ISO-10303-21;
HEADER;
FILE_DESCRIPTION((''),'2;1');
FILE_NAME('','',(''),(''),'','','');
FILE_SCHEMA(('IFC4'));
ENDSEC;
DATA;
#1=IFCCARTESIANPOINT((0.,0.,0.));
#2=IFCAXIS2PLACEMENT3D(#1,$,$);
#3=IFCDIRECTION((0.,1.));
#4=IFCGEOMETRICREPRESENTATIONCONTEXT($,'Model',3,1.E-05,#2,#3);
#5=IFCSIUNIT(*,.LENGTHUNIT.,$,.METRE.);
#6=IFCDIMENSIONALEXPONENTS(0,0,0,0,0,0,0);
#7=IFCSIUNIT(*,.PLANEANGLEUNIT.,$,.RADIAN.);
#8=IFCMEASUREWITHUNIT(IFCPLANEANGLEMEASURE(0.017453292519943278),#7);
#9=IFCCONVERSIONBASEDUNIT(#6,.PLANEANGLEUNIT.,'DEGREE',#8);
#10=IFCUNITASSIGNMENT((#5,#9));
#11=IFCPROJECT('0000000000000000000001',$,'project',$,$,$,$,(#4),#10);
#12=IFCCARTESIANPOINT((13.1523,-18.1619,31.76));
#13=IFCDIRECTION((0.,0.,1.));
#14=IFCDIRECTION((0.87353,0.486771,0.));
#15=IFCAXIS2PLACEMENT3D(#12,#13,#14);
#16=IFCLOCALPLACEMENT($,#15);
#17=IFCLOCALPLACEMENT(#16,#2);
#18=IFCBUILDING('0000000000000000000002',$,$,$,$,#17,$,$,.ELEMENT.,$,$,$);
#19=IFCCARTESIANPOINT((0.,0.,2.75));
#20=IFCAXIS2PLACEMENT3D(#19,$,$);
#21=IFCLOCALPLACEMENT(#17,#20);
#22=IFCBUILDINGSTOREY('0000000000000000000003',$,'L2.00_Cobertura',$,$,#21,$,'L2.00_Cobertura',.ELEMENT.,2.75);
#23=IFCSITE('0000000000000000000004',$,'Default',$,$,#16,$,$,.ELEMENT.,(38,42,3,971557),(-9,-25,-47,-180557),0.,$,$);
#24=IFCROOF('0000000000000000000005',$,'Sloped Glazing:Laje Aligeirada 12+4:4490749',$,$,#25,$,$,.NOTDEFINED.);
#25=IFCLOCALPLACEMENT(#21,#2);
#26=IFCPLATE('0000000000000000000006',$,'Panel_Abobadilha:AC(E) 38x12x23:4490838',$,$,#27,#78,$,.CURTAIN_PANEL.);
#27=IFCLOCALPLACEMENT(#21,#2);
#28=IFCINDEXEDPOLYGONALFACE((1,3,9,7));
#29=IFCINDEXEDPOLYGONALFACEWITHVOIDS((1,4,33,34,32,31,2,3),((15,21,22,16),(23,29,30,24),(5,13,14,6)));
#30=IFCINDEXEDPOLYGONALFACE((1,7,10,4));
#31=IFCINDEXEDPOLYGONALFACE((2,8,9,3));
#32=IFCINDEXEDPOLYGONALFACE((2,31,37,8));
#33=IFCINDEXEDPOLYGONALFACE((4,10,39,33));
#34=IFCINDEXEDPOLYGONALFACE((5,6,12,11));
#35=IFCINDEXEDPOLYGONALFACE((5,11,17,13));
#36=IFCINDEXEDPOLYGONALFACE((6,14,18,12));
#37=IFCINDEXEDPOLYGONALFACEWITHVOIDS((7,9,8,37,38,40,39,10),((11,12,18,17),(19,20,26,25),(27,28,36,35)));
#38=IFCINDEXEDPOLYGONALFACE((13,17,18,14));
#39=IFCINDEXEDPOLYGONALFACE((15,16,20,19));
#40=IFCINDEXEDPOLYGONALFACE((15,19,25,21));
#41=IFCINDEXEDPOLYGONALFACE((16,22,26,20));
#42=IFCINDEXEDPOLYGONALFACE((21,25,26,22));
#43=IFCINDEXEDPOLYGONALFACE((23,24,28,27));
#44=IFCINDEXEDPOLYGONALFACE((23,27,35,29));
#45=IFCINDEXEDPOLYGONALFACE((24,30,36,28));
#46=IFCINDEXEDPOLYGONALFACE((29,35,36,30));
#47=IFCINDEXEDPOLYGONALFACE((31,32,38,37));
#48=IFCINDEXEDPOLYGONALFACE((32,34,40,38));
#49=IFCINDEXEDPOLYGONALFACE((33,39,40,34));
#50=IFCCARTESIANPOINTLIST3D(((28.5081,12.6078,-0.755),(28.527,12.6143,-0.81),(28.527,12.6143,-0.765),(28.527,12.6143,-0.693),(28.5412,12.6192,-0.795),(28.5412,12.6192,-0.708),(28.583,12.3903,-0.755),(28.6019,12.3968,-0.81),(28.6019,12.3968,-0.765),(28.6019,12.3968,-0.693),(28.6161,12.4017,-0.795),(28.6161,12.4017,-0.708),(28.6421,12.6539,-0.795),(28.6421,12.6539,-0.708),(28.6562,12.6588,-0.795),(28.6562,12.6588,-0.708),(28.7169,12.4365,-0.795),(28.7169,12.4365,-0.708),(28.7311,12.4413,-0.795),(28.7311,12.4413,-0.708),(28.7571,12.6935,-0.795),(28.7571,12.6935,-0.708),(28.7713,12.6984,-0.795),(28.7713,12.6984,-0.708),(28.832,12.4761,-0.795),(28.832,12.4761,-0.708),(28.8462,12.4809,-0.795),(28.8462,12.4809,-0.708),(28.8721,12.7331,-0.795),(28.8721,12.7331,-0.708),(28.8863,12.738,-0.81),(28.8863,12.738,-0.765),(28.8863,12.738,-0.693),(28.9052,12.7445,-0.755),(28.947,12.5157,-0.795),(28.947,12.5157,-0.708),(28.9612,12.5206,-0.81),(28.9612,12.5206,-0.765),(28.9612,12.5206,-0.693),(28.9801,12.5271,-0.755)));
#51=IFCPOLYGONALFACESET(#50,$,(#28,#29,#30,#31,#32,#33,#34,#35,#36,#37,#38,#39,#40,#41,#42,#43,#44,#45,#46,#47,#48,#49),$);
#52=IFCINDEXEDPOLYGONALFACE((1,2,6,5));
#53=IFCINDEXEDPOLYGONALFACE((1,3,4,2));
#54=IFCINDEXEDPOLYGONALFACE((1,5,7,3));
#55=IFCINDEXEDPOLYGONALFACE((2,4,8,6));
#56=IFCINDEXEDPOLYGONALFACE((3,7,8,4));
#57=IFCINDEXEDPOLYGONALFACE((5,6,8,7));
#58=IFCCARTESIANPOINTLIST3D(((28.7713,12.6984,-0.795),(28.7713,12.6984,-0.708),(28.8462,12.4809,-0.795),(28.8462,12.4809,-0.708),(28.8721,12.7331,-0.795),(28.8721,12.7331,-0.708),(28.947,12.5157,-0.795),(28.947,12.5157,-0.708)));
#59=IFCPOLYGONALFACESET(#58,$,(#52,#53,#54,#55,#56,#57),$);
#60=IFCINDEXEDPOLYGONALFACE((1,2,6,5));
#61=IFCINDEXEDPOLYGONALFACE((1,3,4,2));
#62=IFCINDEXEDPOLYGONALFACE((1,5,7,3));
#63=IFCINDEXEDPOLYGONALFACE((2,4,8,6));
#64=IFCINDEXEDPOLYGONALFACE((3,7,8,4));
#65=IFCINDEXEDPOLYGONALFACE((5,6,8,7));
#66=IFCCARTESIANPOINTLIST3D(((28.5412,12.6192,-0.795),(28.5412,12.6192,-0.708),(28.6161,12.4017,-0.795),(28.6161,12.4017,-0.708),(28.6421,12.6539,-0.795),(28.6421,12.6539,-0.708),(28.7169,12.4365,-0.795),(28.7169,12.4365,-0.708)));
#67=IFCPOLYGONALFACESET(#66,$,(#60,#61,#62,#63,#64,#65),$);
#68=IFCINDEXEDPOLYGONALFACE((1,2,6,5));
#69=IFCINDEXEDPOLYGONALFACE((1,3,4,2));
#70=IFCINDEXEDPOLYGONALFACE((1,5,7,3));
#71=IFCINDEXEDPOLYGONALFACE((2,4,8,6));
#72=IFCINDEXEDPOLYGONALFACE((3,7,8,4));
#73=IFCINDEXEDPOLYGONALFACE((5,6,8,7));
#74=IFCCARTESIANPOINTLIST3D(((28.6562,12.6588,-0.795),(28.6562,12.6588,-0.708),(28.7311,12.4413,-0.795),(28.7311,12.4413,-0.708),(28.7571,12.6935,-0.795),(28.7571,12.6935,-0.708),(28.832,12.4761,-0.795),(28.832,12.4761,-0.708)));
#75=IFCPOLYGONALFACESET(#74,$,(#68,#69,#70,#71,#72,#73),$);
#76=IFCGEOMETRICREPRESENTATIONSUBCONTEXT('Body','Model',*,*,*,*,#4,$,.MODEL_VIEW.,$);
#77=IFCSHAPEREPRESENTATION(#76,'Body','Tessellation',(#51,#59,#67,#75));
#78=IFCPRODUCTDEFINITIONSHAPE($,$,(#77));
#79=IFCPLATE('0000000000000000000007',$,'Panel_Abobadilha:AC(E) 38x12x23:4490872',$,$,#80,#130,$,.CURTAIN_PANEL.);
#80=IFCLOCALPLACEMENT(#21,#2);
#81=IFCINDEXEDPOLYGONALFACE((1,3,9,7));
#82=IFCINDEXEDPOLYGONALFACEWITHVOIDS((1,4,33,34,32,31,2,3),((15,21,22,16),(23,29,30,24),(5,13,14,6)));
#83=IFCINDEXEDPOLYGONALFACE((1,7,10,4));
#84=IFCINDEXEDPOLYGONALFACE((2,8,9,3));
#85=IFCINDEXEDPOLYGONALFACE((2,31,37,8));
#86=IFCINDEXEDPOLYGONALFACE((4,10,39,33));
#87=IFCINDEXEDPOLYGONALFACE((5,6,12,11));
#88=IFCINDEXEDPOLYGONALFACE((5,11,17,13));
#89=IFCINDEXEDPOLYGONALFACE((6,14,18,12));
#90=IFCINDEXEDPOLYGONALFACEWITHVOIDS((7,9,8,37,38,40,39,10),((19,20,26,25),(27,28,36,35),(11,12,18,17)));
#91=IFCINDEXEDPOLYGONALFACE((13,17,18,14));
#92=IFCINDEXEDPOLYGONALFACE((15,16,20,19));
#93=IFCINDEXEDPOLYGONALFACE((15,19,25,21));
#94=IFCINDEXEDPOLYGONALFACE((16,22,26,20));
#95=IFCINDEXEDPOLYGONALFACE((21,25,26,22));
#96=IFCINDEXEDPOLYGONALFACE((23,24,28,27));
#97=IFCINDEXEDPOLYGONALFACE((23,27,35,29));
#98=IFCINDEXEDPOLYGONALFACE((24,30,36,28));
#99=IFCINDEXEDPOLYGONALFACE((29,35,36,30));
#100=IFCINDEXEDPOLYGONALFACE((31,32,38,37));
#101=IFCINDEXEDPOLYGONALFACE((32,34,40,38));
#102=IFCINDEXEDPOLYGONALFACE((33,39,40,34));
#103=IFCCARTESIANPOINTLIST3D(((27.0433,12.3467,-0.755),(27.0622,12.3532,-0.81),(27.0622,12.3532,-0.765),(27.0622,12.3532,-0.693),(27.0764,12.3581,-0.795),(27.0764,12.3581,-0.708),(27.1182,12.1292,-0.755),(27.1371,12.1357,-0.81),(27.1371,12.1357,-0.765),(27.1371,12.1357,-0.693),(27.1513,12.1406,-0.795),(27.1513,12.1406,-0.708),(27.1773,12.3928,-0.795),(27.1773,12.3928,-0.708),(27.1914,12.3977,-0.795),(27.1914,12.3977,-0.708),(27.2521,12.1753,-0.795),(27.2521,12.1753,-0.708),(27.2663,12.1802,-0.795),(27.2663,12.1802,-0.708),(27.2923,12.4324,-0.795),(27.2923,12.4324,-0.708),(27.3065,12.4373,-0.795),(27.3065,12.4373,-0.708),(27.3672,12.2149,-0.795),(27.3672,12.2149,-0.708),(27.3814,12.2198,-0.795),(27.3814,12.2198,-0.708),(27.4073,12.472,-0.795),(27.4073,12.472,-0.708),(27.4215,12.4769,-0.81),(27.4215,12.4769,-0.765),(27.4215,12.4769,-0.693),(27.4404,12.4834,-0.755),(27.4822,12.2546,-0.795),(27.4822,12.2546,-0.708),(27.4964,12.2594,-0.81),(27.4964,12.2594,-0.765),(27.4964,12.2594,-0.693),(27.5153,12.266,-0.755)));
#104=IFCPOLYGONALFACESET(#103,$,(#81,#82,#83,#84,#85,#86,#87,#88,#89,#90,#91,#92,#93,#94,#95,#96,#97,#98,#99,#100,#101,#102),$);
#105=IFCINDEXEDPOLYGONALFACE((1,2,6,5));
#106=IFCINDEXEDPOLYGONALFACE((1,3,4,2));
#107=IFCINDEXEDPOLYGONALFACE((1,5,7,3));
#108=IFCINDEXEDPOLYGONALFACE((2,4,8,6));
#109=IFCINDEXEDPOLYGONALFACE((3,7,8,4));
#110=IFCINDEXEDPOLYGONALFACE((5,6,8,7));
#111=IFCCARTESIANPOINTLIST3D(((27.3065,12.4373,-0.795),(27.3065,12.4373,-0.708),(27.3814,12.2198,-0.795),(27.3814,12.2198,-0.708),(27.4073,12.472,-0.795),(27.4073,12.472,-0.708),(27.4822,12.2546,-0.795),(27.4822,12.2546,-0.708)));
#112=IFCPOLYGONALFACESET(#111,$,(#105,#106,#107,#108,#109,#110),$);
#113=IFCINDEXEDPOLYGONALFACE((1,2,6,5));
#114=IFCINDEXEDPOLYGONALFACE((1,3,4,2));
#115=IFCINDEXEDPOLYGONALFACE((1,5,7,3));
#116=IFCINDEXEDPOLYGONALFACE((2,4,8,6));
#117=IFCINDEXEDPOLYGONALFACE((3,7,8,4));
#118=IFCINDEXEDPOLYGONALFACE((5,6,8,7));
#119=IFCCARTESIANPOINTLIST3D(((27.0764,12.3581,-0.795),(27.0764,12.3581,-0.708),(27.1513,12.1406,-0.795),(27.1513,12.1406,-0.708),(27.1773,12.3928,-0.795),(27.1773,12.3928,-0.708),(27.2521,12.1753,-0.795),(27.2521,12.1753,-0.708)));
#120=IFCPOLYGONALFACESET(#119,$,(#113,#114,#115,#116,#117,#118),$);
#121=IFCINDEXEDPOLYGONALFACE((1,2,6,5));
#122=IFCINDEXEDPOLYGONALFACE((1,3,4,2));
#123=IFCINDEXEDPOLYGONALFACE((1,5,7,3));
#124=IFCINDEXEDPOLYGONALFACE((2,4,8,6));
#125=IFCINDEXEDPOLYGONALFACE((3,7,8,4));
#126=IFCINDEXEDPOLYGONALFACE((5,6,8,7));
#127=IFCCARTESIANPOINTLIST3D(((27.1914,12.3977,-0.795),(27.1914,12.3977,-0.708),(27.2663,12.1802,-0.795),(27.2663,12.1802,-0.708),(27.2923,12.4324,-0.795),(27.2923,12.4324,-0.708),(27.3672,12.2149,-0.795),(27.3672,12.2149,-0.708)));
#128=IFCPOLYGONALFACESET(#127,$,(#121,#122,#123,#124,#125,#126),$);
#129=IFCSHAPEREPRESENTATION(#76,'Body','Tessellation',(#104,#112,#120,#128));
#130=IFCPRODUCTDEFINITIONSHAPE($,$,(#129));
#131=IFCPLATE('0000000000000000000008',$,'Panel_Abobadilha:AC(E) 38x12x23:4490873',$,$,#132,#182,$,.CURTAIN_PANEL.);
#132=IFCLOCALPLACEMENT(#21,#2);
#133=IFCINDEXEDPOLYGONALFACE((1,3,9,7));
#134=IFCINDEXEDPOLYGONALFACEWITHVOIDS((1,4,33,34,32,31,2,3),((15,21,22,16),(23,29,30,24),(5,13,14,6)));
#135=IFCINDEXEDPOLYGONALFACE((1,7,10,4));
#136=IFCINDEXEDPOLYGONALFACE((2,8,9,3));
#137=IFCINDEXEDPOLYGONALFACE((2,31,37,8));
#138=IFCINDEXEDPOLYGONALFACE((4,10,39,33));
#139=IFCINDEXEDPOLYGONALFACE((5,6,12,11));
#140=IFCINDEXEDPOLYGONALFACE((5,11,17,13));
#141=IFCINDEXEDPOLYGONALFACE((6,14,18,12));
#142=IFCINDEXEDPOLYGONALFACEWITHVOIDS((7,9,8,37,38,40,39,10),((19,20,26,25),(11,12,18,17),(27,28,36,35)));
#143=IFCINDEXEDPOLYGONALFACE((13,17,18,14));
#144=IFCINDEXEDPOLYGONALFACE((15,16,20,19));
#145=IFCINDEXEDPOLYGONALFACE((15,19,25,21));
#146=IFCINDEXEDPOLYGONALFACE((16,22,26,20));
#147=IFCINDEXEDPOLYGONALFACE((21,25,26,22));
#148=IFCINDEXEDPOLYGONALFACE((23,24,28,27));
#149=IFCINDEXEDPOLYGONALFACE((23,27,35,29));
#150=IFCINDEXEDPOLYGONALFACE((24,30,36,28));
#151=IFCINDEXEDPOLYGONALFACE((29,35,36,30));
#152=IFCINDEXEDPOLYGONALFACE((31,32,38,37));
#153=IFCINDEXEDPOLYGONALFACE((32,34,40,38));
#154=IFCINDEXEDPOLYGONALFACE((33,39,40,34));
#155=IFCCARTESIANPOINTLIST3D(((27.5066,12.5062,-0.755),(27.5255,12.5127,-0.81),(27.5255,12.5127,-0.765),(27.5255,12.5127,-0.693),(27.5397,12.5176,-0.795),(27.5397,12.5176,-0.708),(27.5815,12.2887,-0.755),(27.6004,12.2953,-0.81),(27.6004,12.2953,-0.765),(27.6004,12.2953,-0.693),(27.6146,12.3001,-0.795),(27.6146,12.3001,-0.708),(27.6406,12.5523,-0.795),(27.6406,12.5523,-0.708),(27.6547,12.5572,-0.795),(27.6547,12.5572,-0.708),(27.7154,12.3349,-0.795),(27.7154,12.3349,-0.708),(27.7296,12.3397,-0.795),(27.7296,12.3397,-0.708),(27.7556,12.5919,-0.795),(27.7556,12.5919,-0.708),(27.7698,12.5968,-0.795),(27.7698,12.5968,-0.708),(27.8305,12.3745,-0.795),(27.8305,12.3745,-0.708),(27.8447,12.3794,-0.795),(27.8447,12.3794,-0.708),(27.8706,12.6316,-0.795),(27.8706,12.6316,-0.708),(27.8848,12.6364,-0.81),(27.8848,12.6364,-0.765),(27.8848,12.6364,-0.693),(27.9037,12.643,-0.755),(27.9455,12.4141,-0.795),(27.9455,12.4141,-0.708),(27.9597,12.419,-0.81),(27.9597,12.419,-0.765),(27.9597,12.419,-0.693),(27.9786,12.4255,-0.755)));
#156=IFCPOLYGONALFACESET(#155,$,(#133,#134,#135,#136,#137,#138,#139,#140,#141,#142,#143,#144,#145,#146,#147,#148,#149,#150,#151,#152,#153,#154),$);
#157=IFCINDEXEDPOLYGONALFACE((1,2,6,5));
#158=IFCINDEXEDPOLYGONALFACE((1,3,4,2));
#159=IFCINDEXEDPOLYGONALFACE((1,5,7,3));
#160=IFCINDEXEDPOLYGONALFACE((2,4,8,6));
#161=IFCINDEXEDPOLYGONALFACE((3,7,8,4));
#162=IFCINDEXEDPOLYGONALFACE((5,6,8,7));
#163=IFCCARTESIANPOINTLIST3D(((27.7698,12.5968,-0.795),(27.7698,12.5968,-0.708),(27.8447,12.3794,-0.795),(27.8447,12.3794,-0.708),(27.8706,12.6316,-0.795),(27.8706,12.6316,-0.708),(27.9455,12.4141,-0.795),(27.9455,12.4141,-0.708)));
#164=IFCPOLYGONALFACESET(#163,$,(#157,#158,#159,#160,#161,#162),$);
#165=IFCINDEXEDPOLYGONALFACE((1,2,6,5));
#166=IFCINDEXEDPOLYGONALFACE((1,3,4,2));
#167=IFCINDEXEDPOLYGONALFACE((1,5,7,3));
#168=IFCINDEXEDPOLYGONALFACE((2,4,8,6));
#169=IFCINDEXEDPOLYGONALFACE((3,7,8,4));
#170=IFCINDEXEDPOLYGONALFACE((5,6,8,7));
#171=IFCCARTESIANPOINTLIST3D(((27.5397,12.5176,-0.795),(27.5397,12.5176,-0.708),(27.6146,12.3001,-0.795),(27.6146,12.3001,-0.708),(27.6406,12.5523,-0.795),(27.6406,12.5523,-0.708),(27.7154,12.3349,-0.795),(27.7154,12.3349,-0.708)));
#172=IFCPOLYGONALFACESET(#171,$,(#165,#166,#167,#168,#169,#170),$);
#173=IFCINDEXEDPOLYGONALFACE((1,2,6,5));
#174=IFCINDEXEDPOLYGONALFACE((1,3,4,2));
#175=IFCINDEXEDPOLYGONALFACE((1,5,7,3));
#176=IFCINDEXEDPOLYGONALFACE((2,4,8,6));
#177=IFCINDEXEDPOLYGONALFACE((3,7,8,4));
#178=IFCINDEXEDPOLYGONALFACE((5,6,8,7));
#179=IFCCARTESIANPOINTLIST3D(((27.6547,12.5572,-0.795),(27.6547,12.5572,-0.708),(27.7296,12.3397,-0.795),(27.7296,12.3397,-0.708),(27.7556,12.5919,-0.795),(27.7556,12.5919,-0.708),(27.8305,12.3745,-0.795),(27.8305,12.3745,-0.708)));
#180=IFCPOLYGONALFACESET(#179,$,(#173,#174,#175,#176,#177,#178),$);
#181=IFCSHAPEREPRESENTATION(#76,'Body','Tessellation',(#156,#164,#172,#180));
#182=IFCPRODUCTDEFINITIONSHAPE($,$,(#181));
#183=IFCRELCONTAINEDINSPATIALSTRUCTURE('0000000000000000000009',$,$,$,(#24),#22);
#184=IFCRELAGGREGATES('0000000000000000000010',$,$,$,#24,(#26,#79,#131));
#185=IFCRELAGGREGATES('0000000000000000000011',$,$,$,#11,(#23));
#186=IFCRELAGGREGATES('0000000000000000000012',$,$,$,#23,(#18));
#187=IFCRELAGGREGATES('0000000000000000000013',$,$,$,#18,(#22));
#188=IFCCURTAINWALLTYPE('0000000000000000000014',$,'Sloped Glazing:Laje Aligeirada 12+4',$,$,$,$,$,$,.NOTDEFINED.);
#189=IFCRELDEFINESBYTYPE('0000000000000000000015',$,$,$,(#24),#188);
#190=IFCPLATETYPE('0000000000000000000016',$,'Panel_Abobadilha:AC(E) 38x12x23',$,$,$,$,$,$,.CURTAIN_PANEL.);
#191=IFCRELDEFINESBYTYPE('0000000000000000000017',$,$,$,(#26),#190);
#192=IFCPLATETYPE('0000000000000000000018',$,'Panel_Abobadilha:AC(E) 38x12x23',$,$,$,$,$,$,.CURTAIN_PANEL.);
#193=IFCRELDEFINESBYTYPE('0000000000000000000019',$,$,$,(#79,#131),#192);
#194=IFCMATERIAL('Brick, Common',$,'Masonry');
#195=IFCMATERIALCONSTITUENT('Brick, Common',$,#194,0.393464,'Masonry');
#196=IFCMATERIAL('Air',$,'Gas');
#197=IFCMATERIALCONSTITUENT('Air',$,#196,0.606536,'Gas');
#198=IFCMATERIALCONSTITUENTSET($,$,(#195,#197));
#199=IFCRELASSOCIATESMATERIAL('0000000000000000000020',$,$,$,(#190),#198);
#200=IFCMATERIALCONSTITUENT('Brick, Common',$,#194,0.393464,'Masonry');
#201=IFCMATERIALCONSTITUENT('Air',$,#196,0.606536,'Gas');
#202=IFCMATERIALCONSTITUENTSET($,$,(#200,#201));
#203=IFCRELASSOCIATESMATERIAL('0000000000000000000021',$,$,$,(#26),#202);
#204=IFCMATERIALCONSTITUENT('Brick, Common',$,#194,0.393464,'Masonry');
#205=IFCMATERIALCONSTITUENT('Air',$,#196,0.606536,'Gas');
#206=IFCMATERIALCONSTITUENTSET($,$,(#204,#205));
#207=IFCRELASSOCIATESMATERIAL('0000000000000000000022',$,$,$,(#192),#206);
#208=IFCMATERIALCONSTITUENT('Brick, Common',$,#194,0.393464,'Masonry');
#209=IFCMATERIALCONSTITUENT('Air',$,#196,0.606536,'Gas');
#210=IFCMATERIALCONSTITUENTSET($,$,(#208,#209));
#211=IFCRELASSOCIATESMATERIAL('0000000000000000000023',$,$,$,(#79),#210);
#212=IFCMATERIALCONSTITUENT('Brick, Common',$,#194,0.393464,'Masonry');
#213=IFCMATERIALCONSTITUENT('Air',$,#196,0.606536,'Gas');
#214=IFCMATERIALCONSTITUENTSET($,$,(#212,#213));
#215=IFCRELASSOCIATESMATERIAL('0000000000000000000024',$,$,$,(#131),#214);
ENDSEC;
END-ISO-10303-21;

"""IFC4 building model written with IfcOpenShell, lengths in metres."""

from ifc_helpers import new_model, entity, si_unit, converted_unit, direction, frame, origin, place, context, subcontext, project, spatial, indexed_curve, outline, extrude, source, transform, mapped, material, constituent, constituent_set, type_object, type_shapes, element, aggregate, save


model = new_model("IFC4")

# Units and contexts
model_context = context("Model", 3, precision=1e-05, world=origin(), true_north=direction((0.0, 1.0)))
body_context = subcontext(model_context, "Body", "Model", "MODEL_VIEW")
ifc_project = project(units=[si_unit("LENGTHUNIT", "METRE"), converted_unit("PLANEANGLEUNIT", "DEGREE", entity("IfcPlaneAngleMeasure", 0.017453292519943278), si_unit("PLANEANGLEUNIT", "RADIAN"), dimensions=[0, 0, 0, 0, 0, 0, 0])], contexts=[model_context])

# Site, building, storey
site_placement = place(None, frame((13.1523, -18.1619, 31.76), z_axis=(0.0, 0.0, 1.0), x_axis=(0.87353, 0.486771, 0.0)))
site = spatial("IfcSite", under=ifc_project, at=site_placement, Name="Default", CompositionType="ELEMENT", RefLatitude=(38, 42, 3, 971557), RefLongitude=(-9, -25, -47, -180557), RefElevation=0.0)
building_placement = place(site_placement, origin())
building = spatial("IfcBuilding", under=site, at=building_placement, CompositionType="ELEMENT")
storey_placement = place(building_placement, frame((0.0, 0.0, 2.75)))
storey = spatial("IfcBuildingStorey", under=building, at=storey_placement, Name="L2.00_Cobertura", LongName="L2.00_Cobertura", CompositionType="ELEMENT", Elevation=2.75)

# Roof, plates
curtain_wall_type = type_object("IfcCurtainWallType", Name="Sloped Glazing:Laje Aligeirada 12+4", PredefinedType="NOTDEFINED")
roof_placement = place(storey_placement, frame((0.0, 0.0, -2.75)))
roof = element("IfcRoof", 1, at=roof_placement, inside=storey, type_object=curtain_wall_type, Name="Sloped Glazing:Laje Aligeirada 12+4:4490749", PredefinedType="NOTDEFINED")
ifc_material_1 = material(Name="Brick, Common", Category="Masonry")
ifc_material_2 = material(Name="Air", Category="Gas")
ifc_constituent_1 = constituent(ifc_material_1, Name="Brick, Common", Category="Masonry", fraction=0.393464)
ifc_constituent_2 = constituent(ifc_material_2, Name="Air", Category="Gas", fraction=0.606536)
ifc_constituent_set_1 = constituent_set(constituents=[ifc_constituent_1, ifc_constituent_2])
plate_type_1 = type_object("IfcPlateType", Name="Panel_Abobadilha:AC(E) 38x12x23", PredefinedType="CURTAIN_PANEL", material=ifc_constituent_set_1)
shared_shape_1 = source(origin(), body_context, "Body", "SweptSolid", [
    extrude(outline(indexed_curve([(-0.19, -0.0543), (0.19, -0.0543), (0.19, -0.0093), (0.21, 0.0007), (0.19, 0.0628), (-0.19, 0.0628), (-0.21, 0.0007), (-0.19, -0.0093), (-0.19, -0.0543)], self_intersect=False), holes=[indexed_curve([(-0.0683, 0.0477), (-0.0683, -0.0393), (-0.175, -0.0393), (-0.175, 0.0477), (-0.0683, 0.0477)], self_intersect=False), indexed_curve([(0.0533, 0.0477), (0.0533, -0.0393), (-0.0533, -0.0393), (-0.0533, 0.0477), (0.0533, 0.0477)], self_intersect=False), indexed_curve([(0.175, 0.0477), (0.175, -0.0393), (0.0683, -0.0393), (0.0683, 0.0477), (0.175, 0.0477)], self_intersect=False)]), frame((0.0, 0.0543, 0.0)), (0.0, 0.0, 1.0), 0.23),
    extrude(outline(indexed_curve([(-0.0533, -0.0435), (0.0533, -0.0435), (0.0533, 0.0435), (-0.0533, 0.0435), (-0.0533, -0.0435)], self_intersect=False)), frame((0.1217, 0.0585, 0.0), z_axis=(0.0, 0.0, 1.0), x_axis=(-1.0, 0.0, 0.0)), (0.0, 0.0, 1.0), 0.23),
    extrude(outline(indexed_curve([(-0.0533, -0.0435), (0.0533, -0.0435), (0.0533, 0.0435), (-0.0533, 0.0435), (-0.0533, -0.0435)], self_intersect=False)), frame((-0.1217, 0.0585, 0.0), z_axis=(0.0, 0.0, 1.0), x_axis=(-1.0, 0.0, 0.0)), (0.0, 0.0, 1.0), 0.23),
    extrude(outline(indexed_curve([(-0.0533, -0.0435), (0.0533, -0.0435), (0.0533, 0.0435), (-0.0533, 0.0435), (-0.0533, -0.0435)], self_intersect=False)), frame((0.0, 0.0585, 0.0), z_axis=(0.0, 0.0, 1.0), x_axis=(-1.0, 0.0, 0.0)), (0.0, 0.0, 1.0), 0.23),
])
type_shapes(plate_type_1, [shared_shape_1])
ifc_constituent_3 = constituent(ifc_material_1, Name="Brick, Common", Category="Masonry", fraction=0.393464)
ifc_constituent_4 = constituent(ifc_material_2, Name="Air", Category="Gas", fraction=0.606536)
ifc_constituent_set_2 = constituent_set(constituents=[ifc_constituent_3, ifc_constituent_4])
plate_1_placement = place(roof_placement, frame((28.7067, 12.6762, 1.94), z_axis=(0.325568, -0.945519, 0.0), x_axis=(0.945519, 0.325568, 0.0)))
plate_1 = element("IfcPlate", 2, at=plate_1_placement, type_object=plate_type_1, material=ifc_constituent_set_2, Name="Panel_Abobadilha:AC(E) 38x12x23:4490838", PredefinedType="CURTAIN_PANEL", context=body_context, shape_type="MappedRepresentation", body=[
    mapped(shared_shape_1, transform((0.0, 0.0, 0.0), scale=1.0)),
])
ifc_constituent_5 = constituent(ifc_material_1, Name="Brick, Common", Category="Masonry", fraction=0.393464)
ifc_constituent_6 = constituent(ifc_material_2, Name="Air", Category="Gas", fraction=0.606536)
ifc_constituent_set_3 = constituent_set(constituents=[ifc_constituent_5, ifc_constituent_6])
ifc_constituent_7 = constituent(ifc_material_1, Name="Brick, Common", Category="Masonry", fraction=0.393464)
ifc_constituent_8 = constituent(ifc_material_2, Name="Air", Category="Gas", fraction=0.606536)
ifc_constituent_set_4 = constituent_set(constituents=[ifc_constituent_7, ifc_constituent_8])
plate_type_2 = type_object("IfcPlateType", Name="Panel_Abobadilha:AC(E) 38x12x23", PredefinedType="CURTAIN_PANEL", material=ifc_constituent_set_4)
shared_shape_2 = source(origin(), body_context, "Body", "SweptSolid", [
    extrude(outline(indexed_curve([(-0.19, -0.0543), (0.19, -0.0543), (0.19, -0.0093), (0.21, 0.0007), (0.19, 0.0628), (-0.19, 0.0628), (-0.21, 0.0007), (-0.19, -0.0093), (-0.19, -0.0543)], self_intersect=False), holes=[indexed_curve([(-0.0683, 0.0477), (-0.0683, -0.0393), (-0.175, -0.0393), (-0.175, 0.0477), (-0.0683, 0.0477)], self_intersect=False), indexed_curve([(0.0533, 0.0477), (0.0533, -0.0393), (-0.0533, -0.0393), (-0.0533, 0.0477), (0.0533, 0.0477)], self_intersect=False), indexed_curve([(0.175, 0.0477), (0.175, -0.0393), (0.0683, -0.0393), (0.0683, 0.0477), (0.175, 0.0477)], self_intersect=False)]), frame((0.0, 0.0543, 0.0)), (0.0, 0.0, 1.0), 0.23),
    extrude(outline(indexed_curve([(-0.0533, -0.0435), (0.0533, -0.0435), (0.0533, 0.0435), (-0.0533, 0.0435), (-0.0533, -0.0435)], self_intersect=False)), frame((0.1217, 0.0585, 0.0), z_axis=(0.0, 0.0, 1.0), x_axis=(-1.0, 0.0, 0.0)), (0.0, 0.0, 1.0), 0.23),
    extrude(outline(indexed_curve([(-0.0533, -0.0435), (0.0533, -0.0435), (0.0533, 0.0435), (-0.0533, 0.0435), (-0.0533, -0.0435)], self_intersect=False)), frame((-0.1217, 0.0585, 0.0), z_axis=(0.0, 0.0, 1.0), x_axis=(-1.0, 0.0, 0.0)), (0.0, 0.0, 1.0), 0.23),
    extrude(outline(indexed_curve([(-0.0533, -0.0435), (0.0533, -0.0435), (0.0533, 0.0435), (-0.0533, 0.0435), (-0.0533, -0.0435)], self_intersect=False)), frame((0.0, 0.0585, 0.0), z_axis=(0.0, 0.0, 1.0), x_axis=(-1.0, 0.0, 0.0)), (0.0, 0.0, 1.0), 0.23),
])
type_shapes(plate_type_2, [shared_shape_2])
plate_2_placement = place(roof_placement, frame((27.2419, 12.4151, 1.94), z_axis=(0.325568, -0.945519, 0.0), x_axis=(0.945519, 0.325568, 0.0)))
plate_2 = element("IfcPlate", 3, at=plate_2_placement, type_object=plate_type_2, material=ifc_constituent_set_3, Name="Panel_Abobadilha:AC(E) 38x12x23:4490872", PredefinedType="CURTAIN_PANEL", context=body_context, shape_type="MappedRepresentation", body=[
    mapped(shared_shape_2, transform((0.0, 0.0, 0.0), scale=1.0)),
])
ifc_constituent_9 = constituent(ifc_material_1, Name="Brick, Common", Category="Masonry", fraction=0.393464)
ifc_constituent_10 = constituent(ifc_material_2, Name="Air", Category="Gas", fraction=0.606536)
ifc_constituent_set_5 = constituent_set(constituents=[ifc_constituent_9, ifc_constituent_10])
plate_3_placement = place(roof_placement, frame((27.7052, 12.5746, 1.94), z_axis=(0.325568, -0.945519, 0.0), x_axis=(0.945519, 0.325568, 0.0)))
plate_3 = element("IfcPlate", 4, at=plate_3_placement, type_object=plate_type_2, material=ifc_constituent_set_5, Name="Panel_Abobadilha:AC(E) 38x12x23:4490873", PredefinedType="CURTAIN_PANEL", context=body_context, shape_type="MappedRepresentation", body=[
    mapped(shared_shape_2, transform((0.0, 0.0, 0.0), scale=1.0)),
])
aggregate(roof, [plate_1, plate_2, plate_3])

save(model, "model.ifc")
